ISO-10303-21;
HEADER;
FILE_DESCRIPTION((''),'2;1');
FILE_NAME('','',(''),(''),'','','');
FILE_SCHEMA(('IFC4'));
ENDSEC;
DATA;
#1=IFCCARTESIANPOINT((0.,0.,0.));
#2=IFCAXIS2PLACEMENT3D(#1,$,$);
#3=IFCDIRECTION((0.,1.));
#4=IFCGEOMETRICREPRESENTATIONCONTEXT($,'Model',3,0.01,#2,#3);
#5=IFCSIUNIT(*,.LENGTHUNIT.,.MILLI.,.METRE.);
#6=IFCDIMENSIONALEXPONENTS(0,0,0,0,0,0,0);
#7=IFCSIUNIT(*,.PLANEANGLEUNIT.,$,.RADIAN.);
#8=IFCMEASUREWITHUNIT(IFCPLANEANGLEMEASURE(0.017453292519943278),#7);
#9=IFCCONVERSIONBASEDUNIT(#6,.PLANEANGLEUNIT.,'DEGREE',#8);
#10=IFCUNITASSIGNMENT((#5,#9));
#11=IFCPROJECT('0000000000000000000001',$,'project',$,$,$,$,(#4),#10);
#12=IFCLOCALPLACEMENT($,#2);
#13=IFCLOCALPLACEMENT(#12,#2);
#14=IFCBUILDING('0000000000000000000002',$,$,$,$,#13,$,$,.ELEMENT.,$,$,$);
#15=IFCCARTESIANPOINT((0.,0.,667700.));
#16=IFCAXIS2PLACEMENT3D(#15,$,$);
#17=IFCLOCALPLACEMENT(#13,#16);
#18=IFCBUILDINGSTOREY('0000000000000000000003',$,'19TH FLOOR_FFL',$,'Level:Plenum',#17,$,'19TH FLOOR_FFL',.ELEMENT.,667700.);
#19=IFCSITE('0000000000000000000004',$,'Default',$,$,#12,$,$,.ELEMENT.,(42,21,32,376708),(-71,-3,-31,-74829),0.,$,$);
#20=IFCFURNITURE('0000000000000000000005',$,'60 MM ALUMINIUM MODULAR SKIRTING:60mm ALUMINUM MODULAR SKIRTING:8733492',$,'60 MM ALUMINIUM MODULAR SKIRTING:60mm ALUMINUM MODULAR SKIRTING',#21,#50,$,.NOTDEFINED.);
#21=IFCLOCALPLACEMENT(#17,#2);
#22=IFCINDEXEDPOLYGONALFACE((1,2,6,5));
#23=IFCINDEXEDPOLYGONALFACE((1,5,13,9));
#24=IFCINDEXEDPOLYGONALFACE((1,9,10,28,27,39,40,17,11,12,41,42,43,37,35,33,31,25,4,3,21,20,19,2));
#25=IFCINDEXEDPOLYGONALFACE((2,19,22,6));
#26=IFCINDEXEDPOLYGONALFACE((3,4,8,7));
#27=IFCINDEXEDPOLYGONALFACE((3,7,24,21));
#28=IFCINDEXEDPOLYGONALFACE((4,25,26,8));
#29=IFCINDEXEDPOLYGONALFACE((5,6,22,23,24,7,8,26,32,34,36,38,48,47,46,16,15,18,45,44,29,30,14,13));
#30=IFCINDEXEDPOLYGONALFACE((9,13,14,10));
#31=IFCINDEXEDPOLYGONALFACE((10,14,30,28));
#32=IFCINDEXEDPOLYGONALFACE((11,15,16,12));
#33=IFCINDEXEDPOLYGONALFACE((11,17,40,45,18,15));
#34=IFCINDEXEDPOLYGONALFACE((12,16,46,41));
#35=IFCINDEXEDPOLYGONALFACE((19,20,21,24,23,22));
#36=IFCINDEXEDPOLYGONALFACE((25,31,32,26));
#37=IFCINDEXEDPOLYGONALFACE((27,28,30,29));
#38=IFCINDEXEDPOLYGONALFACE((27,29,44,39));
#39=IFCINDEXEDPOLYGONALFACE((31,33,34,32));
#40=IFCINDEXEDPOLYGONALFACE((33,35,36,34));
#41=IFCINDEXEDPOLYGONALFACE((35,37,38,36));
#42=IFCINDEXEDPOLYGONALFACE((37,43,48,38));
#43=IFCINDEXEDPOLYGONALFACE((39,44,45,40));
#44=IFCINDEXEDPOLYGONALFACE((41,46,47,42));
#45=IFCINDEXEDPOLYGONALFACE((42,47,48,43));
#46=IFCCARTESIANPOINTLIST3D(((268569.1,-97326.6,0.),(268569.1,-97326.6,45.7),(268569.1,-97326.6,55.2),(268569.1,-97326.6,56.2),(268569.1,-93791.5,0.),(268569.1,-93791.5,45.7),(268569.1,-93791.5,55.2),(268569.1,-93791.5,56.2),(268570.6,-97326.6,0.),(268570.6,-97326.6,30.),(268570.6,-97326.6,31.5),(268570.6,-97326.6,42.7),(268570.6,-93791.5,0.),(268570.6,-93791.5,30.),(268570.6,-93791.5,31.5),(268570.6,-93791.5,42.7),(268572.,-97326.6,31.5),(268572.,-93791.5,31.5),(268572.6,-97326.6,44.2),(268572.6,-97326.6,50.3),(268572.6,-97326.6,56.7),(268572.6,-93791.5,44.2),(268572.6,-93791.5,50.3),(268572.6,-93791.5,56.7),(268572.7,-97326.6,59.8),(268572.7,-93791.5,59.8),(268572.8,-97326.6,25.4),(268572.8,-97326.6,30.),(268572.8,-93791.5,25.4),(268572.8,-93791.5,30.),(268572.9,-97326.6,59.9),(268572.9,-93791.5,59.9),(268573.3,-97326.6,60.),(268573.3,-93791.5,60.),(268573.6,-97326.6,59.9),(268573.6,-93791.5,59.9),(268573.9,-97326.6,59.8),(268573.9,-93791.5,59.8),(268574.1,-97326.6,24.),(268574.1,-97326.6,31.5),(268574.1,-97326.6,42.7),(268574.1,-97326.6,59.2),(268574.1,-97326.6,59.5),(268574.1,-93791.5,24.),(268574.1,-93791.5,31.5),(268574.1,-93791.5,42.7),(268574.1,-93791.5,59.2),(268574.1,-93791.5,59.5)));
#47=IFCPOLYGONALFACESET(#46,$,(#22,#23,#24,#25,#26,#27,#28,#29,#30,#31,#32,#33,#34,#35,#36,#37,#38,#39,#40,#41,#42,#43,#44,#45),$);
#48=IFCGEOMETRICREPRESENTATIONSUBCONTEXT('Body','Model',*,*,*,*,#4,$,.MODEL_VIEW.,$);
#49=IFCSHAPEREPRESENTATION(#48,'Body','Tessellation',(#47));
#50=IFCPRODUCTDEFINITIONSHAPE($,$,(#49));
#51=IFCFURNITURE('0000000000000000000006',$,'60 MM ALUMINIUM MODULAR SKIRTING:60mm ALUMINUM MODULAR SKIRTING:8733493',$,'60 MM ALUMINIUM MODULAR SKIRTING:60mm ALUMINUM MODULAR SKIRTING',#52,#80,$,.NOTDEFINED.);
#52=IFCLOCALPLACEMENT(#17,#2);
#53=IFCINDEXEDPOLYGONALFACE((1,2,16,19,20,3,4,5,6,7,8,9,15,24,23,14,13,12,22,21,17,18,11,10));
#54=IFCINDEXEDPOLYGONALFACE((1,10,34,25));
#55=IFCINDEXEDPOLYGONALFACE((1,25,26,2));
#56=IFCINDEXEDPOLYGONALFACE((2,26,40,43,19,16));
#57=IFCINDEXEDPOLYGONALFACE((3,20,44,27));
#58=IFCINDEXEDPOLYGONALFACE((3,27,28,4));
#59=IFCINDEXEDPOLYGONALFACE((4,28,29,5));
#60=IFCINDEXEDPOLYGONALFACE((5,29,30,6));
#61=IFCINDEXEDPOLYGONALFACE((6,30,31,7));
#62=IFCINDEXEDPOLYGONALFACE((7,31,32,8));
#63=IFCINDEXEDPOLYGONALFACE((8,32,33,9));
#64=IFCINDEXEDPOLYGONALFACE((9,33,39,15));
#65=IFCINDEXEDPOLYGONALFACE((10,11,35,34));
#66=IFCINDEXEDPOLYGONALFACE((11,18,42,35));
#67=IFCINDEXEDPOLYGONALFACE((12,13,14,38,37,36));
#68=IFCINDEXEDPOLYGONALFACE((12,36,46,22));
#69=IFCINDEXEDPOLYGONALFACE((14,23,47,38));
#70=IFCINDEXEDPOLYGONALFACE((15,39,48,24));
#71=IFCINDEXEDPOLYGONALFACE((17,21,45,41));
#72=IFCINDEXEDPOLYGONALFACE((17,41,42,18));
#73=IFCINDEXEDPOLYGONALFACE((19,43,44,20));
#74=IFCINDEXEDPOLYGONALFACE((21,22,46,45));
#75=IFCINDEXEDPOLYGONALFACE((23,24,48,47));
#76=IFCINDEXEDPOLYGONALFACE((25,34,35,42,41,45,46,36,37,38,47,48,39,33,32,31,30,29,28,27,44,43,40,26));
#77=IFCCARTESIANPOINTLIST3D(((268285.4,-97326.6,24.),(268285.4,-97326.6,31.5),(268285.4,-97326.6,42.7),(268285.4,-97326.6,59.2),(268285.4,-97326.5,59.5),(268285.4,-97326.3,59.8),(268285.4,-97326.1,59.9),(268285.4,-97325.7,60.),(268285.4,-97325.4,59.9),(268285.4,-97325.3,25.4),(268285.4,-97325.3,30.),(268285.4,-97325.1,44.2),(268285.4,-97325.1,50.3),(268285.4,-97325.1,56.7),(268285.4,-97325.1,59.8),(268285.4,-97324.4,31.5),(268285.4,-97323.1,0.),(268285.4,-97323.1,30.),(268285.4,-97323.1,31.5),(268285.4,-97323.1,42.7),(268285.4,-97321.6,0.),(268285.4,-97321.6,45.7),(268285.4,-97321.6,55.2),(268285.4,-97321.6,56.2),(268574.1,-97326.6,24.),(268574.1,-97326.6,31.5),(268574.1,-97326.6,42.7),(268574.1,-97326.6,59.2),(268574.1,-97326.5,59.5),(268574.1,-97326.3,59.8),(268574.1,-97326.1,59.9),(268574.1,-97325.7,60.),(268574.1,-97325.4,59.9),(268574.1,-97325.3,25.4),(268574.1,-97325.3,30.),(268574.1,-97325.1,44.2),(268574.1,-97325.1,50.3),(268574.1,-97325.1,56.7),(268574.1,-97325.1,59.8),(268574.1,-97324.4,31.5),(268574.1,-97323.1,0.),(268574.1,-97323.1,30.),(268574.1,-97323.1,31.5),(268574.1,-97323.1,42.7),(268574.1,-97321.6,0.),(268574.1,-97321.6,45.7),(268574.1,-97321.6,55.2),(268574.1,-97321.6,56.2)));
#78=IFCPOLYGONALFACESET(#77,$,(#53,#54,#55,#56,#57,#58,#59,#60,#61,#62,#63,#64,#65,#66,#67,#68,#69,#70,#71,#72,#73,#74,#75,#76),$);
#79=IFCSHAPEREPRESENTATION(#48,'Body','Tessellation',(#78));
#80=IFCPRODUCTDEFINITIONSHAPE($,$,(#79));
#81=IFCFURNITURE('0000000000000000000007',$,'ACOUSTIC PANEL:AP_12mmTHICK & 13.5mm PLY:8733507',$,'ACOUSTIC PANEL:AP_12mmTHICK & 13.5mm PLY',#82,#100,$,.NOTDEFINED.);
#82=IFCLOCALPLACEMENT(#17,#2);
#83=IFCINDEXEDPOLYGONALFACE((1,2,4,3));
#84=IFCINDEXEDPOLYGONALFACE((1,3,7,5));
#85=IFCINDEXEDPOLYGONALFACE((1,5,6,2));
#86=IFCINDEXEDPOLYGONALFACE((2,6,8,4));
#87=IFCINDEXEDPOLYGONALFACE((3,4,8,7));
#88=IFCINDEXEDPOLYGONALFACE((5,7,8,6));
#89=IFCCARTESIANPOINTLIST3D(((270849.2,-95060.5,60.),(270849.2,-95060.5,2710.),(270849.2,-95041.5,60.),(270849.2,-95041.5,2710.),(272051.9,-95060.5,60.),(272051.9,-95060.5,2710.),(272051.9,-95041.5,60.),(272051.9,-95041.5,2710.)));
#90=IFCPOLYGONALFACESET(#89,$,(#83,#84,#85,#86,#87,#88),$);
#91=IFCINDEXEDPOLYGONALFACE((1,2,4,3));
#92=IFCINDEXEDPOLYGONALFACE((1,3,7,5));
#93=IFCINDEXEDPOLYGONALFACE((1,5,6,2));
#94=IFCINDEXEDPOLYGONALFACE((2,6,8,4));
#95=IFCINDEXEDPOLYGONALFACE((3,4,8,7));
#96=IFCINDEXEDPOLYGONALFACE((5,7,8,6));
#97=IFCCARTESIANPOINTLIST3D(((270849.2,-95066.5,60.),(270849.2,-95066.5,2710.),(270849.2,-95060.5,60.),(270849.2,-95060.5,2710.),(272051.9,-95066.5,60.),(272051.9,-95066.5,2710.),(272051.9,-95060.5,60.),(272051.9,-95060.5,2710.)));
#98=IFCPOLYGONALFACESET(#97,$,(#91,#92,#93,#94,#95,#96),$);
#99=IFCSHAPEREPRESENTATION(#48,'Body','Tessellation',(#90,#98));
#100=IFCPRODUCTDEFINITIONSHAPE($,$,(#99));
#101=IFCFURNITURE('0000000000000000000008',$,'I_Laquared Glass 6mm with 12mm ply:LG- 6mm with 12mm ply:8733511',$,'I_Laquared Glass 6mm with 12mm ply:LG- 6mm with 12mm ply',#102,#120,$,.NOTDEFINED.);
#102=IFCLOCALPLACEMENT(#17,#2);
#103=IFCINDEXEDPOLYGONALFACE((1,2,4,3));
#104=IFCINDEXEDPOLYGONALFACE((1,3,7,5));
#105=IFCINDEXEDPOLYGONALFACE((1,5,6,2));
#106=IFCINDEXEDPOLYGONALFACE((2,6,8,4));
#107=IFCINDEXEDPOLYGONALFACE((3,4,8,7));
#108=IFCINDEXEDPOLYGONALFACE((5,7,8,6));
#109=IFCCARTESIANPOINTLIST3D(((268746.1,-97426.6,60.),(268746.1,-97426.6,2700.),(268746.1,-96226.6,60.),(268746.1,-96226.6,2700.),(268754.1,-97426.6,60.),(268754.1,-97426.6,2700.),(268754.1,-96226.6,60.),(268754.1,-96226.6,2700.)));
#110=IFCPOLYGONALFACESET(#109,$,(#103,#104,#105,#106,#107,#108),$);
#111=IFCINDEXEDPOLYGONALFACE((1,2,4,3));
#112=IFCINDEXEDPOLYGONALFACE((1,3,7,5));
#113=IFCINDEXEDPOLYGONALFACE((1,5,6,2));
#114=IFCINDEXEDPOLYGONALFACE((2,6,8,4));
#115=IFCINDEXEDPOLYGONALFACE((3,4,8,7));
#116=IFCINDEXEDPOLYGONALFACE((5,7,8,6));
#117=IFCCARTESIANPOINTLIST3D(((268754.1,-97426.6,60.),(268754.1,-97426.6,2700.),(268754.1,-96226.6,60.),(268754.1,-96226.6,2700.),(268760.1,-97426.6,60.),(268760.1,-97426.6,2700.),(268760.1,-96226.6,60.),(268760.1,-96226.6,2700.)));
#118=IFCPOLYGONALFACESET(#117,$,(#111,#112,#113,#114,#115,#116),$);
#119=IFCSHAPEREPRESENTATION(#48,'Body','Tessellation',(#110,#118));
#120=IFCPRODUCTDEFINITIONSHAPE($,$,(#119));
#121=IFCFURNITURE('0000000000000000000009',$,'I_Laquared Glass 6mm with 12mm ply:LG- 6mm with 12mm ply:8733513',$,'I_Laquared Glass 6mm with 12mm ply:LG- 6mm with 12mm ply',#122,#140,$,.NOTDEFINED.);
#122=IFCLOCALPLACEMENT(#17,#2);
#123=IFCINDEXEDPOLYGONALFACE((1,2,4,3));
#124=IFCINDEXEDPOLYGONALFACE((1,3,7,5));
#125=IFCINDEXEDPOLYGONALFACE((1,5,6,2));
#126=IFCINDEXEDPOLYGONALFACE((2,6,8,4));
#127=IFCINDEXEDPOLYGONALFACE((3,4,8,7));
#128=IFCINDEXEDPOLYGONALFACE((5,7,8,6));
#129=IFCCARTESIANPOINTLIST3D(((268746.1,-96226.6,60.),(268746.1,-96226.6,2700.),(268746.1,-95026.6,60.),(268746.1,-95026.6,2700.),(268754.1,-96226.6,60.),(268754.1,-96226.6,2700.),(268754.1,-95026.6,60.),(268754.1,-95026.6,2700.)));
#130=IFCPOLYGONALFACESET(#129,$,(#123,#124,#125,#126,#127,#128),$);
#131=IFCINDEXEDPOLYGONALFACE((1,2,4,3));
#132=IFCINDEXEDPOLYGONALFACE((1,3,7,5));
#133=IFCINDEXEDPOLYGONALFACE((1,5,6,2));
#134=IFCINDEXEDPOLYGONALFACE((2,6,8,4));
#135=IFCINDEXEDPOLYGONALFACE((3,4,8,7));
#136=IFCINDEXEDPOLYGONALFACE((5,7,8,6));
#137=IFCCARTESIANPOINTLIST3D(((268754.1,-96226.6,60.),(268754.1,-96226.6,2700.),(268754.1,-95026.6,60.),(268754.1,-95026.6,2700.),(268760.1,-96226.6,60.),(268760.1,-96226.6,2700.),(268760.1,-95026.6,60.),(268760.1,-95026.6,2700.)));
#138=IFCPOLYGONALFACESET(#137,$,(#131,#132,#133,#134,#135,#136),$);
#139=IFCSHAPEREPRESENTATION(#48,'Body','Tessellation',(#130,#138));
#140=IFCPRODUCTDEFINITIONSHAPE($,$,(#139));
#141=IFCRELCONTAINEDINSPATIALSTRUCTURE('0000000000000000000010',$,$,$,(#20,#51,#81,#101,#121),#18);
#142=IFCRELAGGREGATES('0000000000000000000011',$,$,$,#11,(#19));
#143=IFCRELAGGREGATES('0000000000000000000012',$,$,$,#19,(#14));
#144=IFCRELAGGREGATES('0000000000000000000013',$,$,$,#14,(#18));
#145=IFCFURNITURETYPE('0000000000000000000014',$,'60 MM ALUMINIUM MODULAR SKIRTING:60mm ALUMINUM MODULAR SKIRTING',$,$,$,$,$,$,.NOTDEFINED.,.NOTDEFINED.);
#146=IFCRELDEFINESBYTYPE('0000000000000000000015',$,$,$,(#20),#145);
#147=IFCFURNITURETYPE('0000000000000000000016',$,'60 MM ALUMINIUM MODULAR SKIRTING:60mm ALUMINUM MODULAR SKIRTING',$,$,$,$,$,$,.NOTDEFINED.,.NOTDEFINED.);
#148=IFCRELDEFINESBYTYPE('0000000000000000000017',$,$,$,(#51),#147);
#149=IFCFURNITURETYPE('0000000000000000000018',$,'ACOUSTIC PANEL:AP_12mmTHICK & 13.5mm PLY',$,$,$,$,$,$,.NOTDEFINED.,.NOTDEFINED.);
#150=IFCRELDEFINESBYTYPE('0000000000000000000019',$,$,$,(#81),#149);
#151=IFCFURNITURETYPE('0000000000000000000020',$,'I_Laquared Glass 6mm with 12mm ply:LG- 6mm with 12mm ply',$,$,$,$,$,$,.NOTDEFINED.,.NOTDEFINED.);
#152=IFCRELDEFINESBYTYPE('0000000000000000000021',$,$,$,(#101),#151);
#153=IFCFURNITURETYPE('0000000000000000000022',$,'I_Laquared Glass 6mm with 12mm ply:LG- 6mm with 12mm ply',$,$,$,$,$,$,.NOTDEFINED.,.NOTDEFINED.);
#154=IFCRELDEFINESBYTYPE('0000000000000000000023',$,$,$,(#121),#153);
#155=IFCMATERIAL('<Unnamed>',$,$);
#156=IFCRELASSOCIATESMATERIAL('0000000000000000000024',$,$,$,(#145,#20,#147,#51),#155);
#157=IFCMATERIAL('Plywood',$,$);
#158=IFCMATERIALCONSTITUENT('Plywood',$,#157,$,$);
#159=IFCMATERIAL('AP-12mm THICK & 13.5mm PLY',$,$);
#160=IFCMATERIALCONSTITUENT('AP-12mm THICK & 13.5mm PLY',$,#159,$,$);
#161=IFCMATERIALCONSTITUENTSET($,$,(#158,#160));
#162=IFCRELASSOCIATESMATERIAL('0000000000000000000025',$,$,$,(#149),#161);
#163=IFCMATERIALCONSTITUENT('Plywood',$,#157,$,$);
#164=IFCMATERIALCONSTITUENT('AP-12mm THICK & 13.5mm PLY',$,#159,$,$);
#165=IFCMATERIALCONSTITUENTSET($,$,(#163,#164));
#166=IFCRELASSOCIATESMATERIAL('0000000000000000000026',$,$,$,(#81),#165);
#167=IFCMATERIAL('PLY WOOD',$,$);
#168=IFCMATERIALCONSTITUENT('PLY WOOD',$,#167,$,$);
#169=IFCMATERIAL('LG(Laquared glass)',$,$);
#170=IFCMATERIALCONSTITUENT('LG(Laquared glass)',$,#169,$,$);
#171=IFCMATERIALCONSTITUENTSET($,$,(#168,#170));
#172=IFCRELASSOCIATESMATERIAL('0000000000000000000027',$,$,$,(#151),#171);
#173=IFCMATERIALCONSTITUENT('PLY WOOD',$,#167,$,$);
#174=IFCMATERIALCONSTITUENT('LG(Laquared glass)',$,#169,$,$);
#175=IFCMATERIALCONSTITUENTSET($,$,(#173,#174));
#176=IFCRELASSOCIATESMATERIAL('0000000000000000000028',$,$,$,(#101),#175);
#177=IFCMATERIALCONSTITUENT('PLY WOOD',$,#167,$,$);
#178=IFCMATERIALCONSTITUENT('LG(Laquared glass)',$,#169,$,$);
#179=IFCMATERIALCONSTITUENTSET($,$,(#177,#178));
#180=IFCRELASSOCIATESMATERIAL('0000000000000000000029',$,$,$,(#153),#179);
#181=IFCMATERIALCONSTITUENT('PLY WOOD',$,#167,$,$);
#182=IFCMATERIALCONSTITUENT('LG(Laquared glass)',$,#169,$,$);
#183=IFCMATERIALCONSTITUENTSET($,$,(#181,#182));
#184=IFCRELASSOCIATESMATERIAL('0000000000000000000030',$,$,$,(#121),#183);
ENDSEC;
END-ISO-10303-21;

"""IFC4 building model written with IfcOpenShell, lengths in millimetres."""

from ifc_helpers import new_model, entity, si_unit, converted_unit, direction, frame, origin, place, context, subcontext, project, spatial, line, arc, indexed_curve, outline, extrude, source, transform, mapped, material, constituent, constituent_set, type_object, type_shapes, element, save


model = new_model("IFC4")

# Units and contexts
model_context = context("Model", 3, precision=0.01, world=origin(), true_north=direction((0.0, 1.0)))
body_context = subcontext(model_context, "Body", "Model", "MODEL_VIEW")
ifc_project = project(units=[si_unit("LENGTHUNIT", "METRE", prefix="MILLI"), converted_unit("PLANEANGLEUNIT", "DEGREE", entity("IfcPlaneAngleMeasure", 0.017453292519943278), si_unit("PLANEANGLEUNIT", "RADIAN"), dimensions=[0, 0, 0, 0, 0, 0, 0])], contexts=[model_context])

# Site, building, storey
site_placement = place(None, origin())
site = spatial("IfcSite", under=ifc_project, at=site_placement, Name="Default", CompositionType="ELEMENT", RefLatitude=(42, 21, 32, 376708), RefLongitude=(-71, -3, -31, -74829), RefElevation=0.0)
building_placement = place(site_placement, origin())
building = spatial("IfcBuilding", under=site, at=building_placement, CompositionType="ELEMENT")
storey_placement = place(building_placement, frame((0.0, 0.0, 667700.0)))
storey = spatial("IfcBuildingStorey", under=building, at=storey_placement, Name="19TH FLOOR_FFL", ObjectType="Level:Plenum", LongName="19TH FLOOR_FFL", CompositionType="ELEMENT", Elevation=667700.0)

# Shared definitions
ifc_material_1 = material(Name="<Unnamed>")

# Furniture
ifc_material_2 = material(Name="Plywood")
ifc_material_3 = material(Name="AP-12mm THICK & 13.5mm PLY")
furniture_type_1 = type_object("IfcFurnitureType", Name="60 MM ALUMINIUM MODULAR SKIRTING:60mm ALUMINUM MODULAR SKIRTING", AssemblyPlace="NOTDEFINED", PredefinedType="NOTDEFINED", material=ifc_material_1)
shared_shape_1 = source(origin(), body_context, "Body", "SweptSolid", [
    extrude(outline(indexed_curve([(-18.5, -2.7), (-17.5, -2.7), (-19.0, 0.8), (-12.6, 0.8), (-6.5, 0.8), (-8.0, -2.7), (37.7, -2.7), (37.7, -1.2), (7.7, -1.2), (7.7, 1.0), (12.3, 1.0), (13.7, 2.4), (6.2, 2.4), (6.2, 0.2), (6.2, -1.2), (-5.0, -1.2), (-5.0, 2.4), (-21.4, 2.3), (-22.2, 1.8), (-22.0, 0.9)], segments=[line(1, 2, 3, 4, 5, 6, 7, 8, 9, 10, 11, 12, 13, 14, 15, 16, 17, 18), arc(18, 19, 20), line(20, 1)], self_intersect=False)), frame((0.0, -2.4, 37.7), z_axis=(1.0, 0.0, 0.0), x_axis=(0.0, 0.0, -1.0)), (0.0, 0.0, 1.0), 3535.2),
])
type_shapes(furniture_type_1, [shared_shape_1])
furniture_1_placement = place(storey_placement, frame((268574.1, -93791.5, 0.0), z_axis=(0.0, 0.0, 1.0), x_axis=(0.0, -1.0, 0.0)))
element("IfcFurniture", 1, at=furniture_1_placement, inside=storey, type_object=furniture_type_1, material=ifc_material_1, Name="60 MM ALUMINIUM MODULAR SKIRTING:60mm ALUMINUM MODULAR SKIRTING:8733492", ObjectType="60 MM ALUMINIUM MODULAR SKIRTING:60mm ALUMINUM MODULAR SKIRTING", PredefinedType="NOTDEFINED", context=body_context, shape_type="MappedRepresentation", body=[
    mapped(shared_shape_1, transform((0.0, 0.0, 0.0), scale=1.0)),
])
furniture_type_2 = type_object("IfcFurnitureType", Name="60 MM ALUMINIUM MODULAR SKIRTING:60mm ALUMINUM MODULAR SKIRTING", AssemblyPlace="NOTDEFINED", PredefinedType="NOTDEFINED", material=ifc_material_1)
shared_shape_2 = source(origin(), body_context, "Body", "SweptSolid", [
    extrude(outline(indexed_curve([(-18.5, -2.7), (-17.5, -2.7), (-19.0, 0.8), (-12.6, 0.8), (-6.5, 0.8), (-8.0, -2.7), (37.7, -2.7), (37.7, -1.2), (7.7, -1.2), (7.7, 1.0), (12.3, 1.0), (13.7, 2.4), (6.2, 2.4), (6.2, 0.2), (6.2, -1.2), (-5.0, -1.2), (-5.0, 2.4), (-21.4, 2.3), (-22.2, 1.8), (-22.0, 0.9)], segments=[line(1, 2, 3, 4, 5, 6, 7, 8, 9, 10, 11, 12, 13, 14, 15, 16, 17, 18), arc(18, 19, 20), line(20, 1)], self_intersect=False)), frame((0.0, -2.4, 37.7), z_axis=(1.0, 0.0, 0.0), x_axis=(0.0, 0.0, -1.0)), (0.0, 0.0, 1.0), 288.7),
])
type_shapes(furniture_type_2, [shared_shape_2])
furniture_2_placement = place(storey_placement, frame((268574.1, -97326.6, 0.0), z_axis=(0.0, 0.0, 1.0), x_axis=(-1.0, 0.0, 0.0)))
element("IfcFurniture", 2, at=furniture_2_placement, inside=storey, type_object=furniture_type_2, material=ifc_material_1, Name="60 MM ALUMINIUM MODULAR SKIRTING:60mm ALUMINUM MODULAR SKIRTING:8733493", ObjectType="60 MM ALUMINIUM MODULAR SKIRTING:60mm ALUMINUM MODULAR SKIRTING", PredefinedType="NOTDEFINED", context=body_context, shape_type="MappedRepresentation", body=[
    mapped(shared_shape_2, transform((0.0, 0.0, 0.0), scale=1.0)),
])
ifc_constituent_1 = constituent(ifc_material_2, Name="Plywood")
ifc_constituent_2 = constituent(ifc_material_3, Name="AP-12mm THICK & 13.5mm PLY")
ifc_constituent_set_1 = constituent_set(constituents=[ifc_constituent_1, ifc_constituent_2])
ifc_constituent_3 = constituent(ifc_material_2, Name="Plywood")
ifc_constituent_4 = constituent(ifc_material_3, Name="AP-12mm THICK & 13.5mm PLY")
ifc_constituent_set_2 = constituent_set(constituents=[ifc_constituent_3, ifc_constituent_4])
furniture_type_3 = type_object("IfcFurnitureType", Name="ACOUSTIC PANEL:AP_12mmTHICK & 13.5mm PLY", AssemblyPlace="NOTDEFINED", PredefinedType="NOTDEFINED", material=ifc_constituent_set_2)
shared_shape_3 = source(origin(), body_context, "Body", "SweptSolid", [
    extrude(outline(indexed_curve([(-601.4, -1325.0), (601.4, -1325.0), (601.4, 1325.0), (-601.4, 1325.0), (-601.4, -1325.0)], self_intersect=False)), frame((0.0, 1325.0, 0.0), z_axis=(0.0, 0.0, 1.0), x_axis=(-1.0, 0.0, 0.0)), (0.0, 0.0, 1.0), 19.0),
    extrude(outline(indexed_curve([(-601.4, -1325.0), (601.4, -1325.0), (601.4, 1325.0), (-601.4, 1325.0), (-601.4, -1325.0)], self_intersect=False)), frame((0.0, 1325.0, 19.0), z_axis=(0.0, 0.0, 1.0), x_axis=(-1.0, 0.0, 0.0)), (0.0, 0.0, 1.0), 6.0),
])
type_shapes(furniture_type_3, [shared_shape_3])
furniture_3_placement = place(storey_placement, frame((271450.6, -95041.5, 60.0), z_axis=(0.0, -1.0, 0.0), x_axis=(1.0, 0.0, 0.0)))
element("IfcFurniture", 3, at=furniture_3_placement, inside=storey, type_object=furniture_type_3, material=ifc_constituent_set_1, Name="ACOUSTIC PANEL:AP_12mmTHICK & 13.5mm PLY:8733507", ObjectType="ACOUSTIC PANEL:AP_12mmTHICK & 13.5mm PLY", PredefinedType="NOTDEFINED", context=body_context, shape_type="MappedRepresentation", body=[
    mapped(shared_shape_3, transform((0.0, 0.0, 0.0), scale=1.0)),
])
ifc_material_4 = material(Name="PLY WOOD")
ifc_constituent_5 = constituent(ifc_material_4, Name="PLY WOOD")
ifc_material_5 = material(Name="LG(Laquared glass)")
ifc_constituent_6 = constituent(ifc_material_5, Name="LG(Laquared glass)")
ifc_constituent_set_3 = constituent_set(constituents=[ifc_constituent_5, ifc_constituent_6])
ifc_constituent_7 = constituent(ifc_material_4, Name="PLY WOOD")
ifc_constituent_8 = constituent(ifc_material_5, Name="LG(Laquared glass)")
ifc_constituent_set_4 = constituent_set(constituents=[ifc_constituent_7, ifc_constituent_8])
furniture_type_4 = type_object("IfcFurnitureType", Name="I_Laquared Glass 6mm with 12mm ply:LG- 6mm with 12mm ply", AssemblyPlace="NOTDEFINED", PredefinedType="NOTDEFINED", material=ifc_constituent_set_4)
shared_shape_4 = source(origin(), body_context, "Body", "SweptSolid", [
    extrude(outline(indexed_curve([(-600.0, -1320.0), (600.0, -1320.0), (600.0, 1320.0), (-600.0, 1320.0), (-600.0, -1320.0)], self_intersect=False)), frame((0.0, 1320.0, 0.0), z_axis=(0.0, 0.0, 1.0), x_axis=(-1.0, 0.0, 0.0)), (0.0, 0.0, 1.0), 8.0),
    extrude(outline(indexed_curve([(-600.0, -1320.0), (600.0, -1320.0), (600.0, 1320.0), (-600.0, 1320.0), (-600.0, -1320.0)], self_intersect=False)), frame((0.0, 1320.0, 8.0), z_axis=(0.0, 0.0, 1.0), x_axis=(-1.0, 0.0, 0.0)), (0.0, 0.0, 1.0), 6.0),
])
type_shapes(furniture_type_4, [shared_shape_4])
furniture_4_placement = place(storey_placement, frame((268746.1, -96826.6, 60.0), z_axis=(1.0, 0.0, 0.0), x_axis=(0.0, 1.0, 0.0)))
element("IfcFurniture", 4, at=furniture_4_placement, inside=storey, type_object=furniture_type_4, material=ifc_constituent_set_3, Name="I_Laquared Glass 6mm with 12mm ply:LG- 6mm with 12mm ply:8733511", ObjectType="I_Laquared Glass 6mm with 12mm ply:LG- 6mm with 12mm ply", PredefinedType="NOTDEFINED", context=body_context, shape_type="MappedRepresentation", body=[
    mapped(shared_shape_4, transform((0.0, 0.0, 0.0), scale=1.0)),
])
ifc_constituent_9 = constituent(ifc_material_4, Name="PLY WOOD")
ifc_constituent_10 = constituent(ifc_material_5, Name="LG(Laquared glass)")
ifc_constituent_set_5 = constituent_set(constituents=[ifc_constituent_9, ifc_constituent_10])
ifc_constituent_11 = constituent(ifc_material_4, Name="PLY WOOD")
ifc_constituent_12 = constituent(ifc_material_5, Name="LG(Laquared glass)")
ifc_constituent_set_6 = constituent_set(constituents=[ifc_constituent_11, ifc_constituent_12])
furniture_type_5 = type_object("IfcFurnitureType", Name="I_Laquared Glass 6mm with 12mm ply:LG- 6mm with 12mm ply", AssemblyPlace="NOTDEFINED", PredefinedType="NOTDEFINED", material=ifc_constituent_set_6)
shared_shape_5 = source(origin(), body_context, "Body", "SweptSolid", [
    extrude(outline(indexed_curve([(-1320.0, -600.0), (1320.0, -600.0), (1320.0, 600.0), (-1320.0, 600.0), (-1320.0, -600.0)], self_intersect=False)), frame((0.0, -1320.0, 0.0), z_axis=(0.0, 0.0, 1.0), x_axis=(0.0, 1.0, 0.0)), (0.0, 0.0, 1.0), 8.0),
    extrude(outline(indexed_curve([(-1320.0, -600.0), (1320.0, -600.0), (1320.0, 600.0), (-1320.0, 600.0), (-1320.0, -600.0)], self_intersect=False)), frame((0.0, -1320.0, 8.0), z_axis=(0.0, 0.0, 1.0), x_axis=(0.0, 1.0, 0.0)), (0.0, 0.0, 1.0), 6.0),
])
type_shapes(furniture_type_5, [shared_shape_5])
furniture_5_placement = place(storey_placement, frame((268746.1, -95626.6, 60.0), z_axis=(1.0, 0.0, 0.0), x_axis=(0.0, -1.0, 0.0)))
element("IfcFurniture", 5, at=furniture_5_placement, inside=storey, type_object=furniture_type_5, material=ifc_constituent_set_5, Name="I_Laquared Glass 6mm with 12mm ply:LG- 6mm with 12mm ply:8733513", ObjectType="I_Laquared Glass 6mm with 12mm ply:LG- 6mm with 12mm ply", PredefinedType="NOTDEFINED", context=body_context, shape_type="MappedRepresentation", body=[
    mapped(shared_shape_5, transform((0.0, 0.0, 0.0), scale=1.0)),
])

save(model, "model.ifc")
